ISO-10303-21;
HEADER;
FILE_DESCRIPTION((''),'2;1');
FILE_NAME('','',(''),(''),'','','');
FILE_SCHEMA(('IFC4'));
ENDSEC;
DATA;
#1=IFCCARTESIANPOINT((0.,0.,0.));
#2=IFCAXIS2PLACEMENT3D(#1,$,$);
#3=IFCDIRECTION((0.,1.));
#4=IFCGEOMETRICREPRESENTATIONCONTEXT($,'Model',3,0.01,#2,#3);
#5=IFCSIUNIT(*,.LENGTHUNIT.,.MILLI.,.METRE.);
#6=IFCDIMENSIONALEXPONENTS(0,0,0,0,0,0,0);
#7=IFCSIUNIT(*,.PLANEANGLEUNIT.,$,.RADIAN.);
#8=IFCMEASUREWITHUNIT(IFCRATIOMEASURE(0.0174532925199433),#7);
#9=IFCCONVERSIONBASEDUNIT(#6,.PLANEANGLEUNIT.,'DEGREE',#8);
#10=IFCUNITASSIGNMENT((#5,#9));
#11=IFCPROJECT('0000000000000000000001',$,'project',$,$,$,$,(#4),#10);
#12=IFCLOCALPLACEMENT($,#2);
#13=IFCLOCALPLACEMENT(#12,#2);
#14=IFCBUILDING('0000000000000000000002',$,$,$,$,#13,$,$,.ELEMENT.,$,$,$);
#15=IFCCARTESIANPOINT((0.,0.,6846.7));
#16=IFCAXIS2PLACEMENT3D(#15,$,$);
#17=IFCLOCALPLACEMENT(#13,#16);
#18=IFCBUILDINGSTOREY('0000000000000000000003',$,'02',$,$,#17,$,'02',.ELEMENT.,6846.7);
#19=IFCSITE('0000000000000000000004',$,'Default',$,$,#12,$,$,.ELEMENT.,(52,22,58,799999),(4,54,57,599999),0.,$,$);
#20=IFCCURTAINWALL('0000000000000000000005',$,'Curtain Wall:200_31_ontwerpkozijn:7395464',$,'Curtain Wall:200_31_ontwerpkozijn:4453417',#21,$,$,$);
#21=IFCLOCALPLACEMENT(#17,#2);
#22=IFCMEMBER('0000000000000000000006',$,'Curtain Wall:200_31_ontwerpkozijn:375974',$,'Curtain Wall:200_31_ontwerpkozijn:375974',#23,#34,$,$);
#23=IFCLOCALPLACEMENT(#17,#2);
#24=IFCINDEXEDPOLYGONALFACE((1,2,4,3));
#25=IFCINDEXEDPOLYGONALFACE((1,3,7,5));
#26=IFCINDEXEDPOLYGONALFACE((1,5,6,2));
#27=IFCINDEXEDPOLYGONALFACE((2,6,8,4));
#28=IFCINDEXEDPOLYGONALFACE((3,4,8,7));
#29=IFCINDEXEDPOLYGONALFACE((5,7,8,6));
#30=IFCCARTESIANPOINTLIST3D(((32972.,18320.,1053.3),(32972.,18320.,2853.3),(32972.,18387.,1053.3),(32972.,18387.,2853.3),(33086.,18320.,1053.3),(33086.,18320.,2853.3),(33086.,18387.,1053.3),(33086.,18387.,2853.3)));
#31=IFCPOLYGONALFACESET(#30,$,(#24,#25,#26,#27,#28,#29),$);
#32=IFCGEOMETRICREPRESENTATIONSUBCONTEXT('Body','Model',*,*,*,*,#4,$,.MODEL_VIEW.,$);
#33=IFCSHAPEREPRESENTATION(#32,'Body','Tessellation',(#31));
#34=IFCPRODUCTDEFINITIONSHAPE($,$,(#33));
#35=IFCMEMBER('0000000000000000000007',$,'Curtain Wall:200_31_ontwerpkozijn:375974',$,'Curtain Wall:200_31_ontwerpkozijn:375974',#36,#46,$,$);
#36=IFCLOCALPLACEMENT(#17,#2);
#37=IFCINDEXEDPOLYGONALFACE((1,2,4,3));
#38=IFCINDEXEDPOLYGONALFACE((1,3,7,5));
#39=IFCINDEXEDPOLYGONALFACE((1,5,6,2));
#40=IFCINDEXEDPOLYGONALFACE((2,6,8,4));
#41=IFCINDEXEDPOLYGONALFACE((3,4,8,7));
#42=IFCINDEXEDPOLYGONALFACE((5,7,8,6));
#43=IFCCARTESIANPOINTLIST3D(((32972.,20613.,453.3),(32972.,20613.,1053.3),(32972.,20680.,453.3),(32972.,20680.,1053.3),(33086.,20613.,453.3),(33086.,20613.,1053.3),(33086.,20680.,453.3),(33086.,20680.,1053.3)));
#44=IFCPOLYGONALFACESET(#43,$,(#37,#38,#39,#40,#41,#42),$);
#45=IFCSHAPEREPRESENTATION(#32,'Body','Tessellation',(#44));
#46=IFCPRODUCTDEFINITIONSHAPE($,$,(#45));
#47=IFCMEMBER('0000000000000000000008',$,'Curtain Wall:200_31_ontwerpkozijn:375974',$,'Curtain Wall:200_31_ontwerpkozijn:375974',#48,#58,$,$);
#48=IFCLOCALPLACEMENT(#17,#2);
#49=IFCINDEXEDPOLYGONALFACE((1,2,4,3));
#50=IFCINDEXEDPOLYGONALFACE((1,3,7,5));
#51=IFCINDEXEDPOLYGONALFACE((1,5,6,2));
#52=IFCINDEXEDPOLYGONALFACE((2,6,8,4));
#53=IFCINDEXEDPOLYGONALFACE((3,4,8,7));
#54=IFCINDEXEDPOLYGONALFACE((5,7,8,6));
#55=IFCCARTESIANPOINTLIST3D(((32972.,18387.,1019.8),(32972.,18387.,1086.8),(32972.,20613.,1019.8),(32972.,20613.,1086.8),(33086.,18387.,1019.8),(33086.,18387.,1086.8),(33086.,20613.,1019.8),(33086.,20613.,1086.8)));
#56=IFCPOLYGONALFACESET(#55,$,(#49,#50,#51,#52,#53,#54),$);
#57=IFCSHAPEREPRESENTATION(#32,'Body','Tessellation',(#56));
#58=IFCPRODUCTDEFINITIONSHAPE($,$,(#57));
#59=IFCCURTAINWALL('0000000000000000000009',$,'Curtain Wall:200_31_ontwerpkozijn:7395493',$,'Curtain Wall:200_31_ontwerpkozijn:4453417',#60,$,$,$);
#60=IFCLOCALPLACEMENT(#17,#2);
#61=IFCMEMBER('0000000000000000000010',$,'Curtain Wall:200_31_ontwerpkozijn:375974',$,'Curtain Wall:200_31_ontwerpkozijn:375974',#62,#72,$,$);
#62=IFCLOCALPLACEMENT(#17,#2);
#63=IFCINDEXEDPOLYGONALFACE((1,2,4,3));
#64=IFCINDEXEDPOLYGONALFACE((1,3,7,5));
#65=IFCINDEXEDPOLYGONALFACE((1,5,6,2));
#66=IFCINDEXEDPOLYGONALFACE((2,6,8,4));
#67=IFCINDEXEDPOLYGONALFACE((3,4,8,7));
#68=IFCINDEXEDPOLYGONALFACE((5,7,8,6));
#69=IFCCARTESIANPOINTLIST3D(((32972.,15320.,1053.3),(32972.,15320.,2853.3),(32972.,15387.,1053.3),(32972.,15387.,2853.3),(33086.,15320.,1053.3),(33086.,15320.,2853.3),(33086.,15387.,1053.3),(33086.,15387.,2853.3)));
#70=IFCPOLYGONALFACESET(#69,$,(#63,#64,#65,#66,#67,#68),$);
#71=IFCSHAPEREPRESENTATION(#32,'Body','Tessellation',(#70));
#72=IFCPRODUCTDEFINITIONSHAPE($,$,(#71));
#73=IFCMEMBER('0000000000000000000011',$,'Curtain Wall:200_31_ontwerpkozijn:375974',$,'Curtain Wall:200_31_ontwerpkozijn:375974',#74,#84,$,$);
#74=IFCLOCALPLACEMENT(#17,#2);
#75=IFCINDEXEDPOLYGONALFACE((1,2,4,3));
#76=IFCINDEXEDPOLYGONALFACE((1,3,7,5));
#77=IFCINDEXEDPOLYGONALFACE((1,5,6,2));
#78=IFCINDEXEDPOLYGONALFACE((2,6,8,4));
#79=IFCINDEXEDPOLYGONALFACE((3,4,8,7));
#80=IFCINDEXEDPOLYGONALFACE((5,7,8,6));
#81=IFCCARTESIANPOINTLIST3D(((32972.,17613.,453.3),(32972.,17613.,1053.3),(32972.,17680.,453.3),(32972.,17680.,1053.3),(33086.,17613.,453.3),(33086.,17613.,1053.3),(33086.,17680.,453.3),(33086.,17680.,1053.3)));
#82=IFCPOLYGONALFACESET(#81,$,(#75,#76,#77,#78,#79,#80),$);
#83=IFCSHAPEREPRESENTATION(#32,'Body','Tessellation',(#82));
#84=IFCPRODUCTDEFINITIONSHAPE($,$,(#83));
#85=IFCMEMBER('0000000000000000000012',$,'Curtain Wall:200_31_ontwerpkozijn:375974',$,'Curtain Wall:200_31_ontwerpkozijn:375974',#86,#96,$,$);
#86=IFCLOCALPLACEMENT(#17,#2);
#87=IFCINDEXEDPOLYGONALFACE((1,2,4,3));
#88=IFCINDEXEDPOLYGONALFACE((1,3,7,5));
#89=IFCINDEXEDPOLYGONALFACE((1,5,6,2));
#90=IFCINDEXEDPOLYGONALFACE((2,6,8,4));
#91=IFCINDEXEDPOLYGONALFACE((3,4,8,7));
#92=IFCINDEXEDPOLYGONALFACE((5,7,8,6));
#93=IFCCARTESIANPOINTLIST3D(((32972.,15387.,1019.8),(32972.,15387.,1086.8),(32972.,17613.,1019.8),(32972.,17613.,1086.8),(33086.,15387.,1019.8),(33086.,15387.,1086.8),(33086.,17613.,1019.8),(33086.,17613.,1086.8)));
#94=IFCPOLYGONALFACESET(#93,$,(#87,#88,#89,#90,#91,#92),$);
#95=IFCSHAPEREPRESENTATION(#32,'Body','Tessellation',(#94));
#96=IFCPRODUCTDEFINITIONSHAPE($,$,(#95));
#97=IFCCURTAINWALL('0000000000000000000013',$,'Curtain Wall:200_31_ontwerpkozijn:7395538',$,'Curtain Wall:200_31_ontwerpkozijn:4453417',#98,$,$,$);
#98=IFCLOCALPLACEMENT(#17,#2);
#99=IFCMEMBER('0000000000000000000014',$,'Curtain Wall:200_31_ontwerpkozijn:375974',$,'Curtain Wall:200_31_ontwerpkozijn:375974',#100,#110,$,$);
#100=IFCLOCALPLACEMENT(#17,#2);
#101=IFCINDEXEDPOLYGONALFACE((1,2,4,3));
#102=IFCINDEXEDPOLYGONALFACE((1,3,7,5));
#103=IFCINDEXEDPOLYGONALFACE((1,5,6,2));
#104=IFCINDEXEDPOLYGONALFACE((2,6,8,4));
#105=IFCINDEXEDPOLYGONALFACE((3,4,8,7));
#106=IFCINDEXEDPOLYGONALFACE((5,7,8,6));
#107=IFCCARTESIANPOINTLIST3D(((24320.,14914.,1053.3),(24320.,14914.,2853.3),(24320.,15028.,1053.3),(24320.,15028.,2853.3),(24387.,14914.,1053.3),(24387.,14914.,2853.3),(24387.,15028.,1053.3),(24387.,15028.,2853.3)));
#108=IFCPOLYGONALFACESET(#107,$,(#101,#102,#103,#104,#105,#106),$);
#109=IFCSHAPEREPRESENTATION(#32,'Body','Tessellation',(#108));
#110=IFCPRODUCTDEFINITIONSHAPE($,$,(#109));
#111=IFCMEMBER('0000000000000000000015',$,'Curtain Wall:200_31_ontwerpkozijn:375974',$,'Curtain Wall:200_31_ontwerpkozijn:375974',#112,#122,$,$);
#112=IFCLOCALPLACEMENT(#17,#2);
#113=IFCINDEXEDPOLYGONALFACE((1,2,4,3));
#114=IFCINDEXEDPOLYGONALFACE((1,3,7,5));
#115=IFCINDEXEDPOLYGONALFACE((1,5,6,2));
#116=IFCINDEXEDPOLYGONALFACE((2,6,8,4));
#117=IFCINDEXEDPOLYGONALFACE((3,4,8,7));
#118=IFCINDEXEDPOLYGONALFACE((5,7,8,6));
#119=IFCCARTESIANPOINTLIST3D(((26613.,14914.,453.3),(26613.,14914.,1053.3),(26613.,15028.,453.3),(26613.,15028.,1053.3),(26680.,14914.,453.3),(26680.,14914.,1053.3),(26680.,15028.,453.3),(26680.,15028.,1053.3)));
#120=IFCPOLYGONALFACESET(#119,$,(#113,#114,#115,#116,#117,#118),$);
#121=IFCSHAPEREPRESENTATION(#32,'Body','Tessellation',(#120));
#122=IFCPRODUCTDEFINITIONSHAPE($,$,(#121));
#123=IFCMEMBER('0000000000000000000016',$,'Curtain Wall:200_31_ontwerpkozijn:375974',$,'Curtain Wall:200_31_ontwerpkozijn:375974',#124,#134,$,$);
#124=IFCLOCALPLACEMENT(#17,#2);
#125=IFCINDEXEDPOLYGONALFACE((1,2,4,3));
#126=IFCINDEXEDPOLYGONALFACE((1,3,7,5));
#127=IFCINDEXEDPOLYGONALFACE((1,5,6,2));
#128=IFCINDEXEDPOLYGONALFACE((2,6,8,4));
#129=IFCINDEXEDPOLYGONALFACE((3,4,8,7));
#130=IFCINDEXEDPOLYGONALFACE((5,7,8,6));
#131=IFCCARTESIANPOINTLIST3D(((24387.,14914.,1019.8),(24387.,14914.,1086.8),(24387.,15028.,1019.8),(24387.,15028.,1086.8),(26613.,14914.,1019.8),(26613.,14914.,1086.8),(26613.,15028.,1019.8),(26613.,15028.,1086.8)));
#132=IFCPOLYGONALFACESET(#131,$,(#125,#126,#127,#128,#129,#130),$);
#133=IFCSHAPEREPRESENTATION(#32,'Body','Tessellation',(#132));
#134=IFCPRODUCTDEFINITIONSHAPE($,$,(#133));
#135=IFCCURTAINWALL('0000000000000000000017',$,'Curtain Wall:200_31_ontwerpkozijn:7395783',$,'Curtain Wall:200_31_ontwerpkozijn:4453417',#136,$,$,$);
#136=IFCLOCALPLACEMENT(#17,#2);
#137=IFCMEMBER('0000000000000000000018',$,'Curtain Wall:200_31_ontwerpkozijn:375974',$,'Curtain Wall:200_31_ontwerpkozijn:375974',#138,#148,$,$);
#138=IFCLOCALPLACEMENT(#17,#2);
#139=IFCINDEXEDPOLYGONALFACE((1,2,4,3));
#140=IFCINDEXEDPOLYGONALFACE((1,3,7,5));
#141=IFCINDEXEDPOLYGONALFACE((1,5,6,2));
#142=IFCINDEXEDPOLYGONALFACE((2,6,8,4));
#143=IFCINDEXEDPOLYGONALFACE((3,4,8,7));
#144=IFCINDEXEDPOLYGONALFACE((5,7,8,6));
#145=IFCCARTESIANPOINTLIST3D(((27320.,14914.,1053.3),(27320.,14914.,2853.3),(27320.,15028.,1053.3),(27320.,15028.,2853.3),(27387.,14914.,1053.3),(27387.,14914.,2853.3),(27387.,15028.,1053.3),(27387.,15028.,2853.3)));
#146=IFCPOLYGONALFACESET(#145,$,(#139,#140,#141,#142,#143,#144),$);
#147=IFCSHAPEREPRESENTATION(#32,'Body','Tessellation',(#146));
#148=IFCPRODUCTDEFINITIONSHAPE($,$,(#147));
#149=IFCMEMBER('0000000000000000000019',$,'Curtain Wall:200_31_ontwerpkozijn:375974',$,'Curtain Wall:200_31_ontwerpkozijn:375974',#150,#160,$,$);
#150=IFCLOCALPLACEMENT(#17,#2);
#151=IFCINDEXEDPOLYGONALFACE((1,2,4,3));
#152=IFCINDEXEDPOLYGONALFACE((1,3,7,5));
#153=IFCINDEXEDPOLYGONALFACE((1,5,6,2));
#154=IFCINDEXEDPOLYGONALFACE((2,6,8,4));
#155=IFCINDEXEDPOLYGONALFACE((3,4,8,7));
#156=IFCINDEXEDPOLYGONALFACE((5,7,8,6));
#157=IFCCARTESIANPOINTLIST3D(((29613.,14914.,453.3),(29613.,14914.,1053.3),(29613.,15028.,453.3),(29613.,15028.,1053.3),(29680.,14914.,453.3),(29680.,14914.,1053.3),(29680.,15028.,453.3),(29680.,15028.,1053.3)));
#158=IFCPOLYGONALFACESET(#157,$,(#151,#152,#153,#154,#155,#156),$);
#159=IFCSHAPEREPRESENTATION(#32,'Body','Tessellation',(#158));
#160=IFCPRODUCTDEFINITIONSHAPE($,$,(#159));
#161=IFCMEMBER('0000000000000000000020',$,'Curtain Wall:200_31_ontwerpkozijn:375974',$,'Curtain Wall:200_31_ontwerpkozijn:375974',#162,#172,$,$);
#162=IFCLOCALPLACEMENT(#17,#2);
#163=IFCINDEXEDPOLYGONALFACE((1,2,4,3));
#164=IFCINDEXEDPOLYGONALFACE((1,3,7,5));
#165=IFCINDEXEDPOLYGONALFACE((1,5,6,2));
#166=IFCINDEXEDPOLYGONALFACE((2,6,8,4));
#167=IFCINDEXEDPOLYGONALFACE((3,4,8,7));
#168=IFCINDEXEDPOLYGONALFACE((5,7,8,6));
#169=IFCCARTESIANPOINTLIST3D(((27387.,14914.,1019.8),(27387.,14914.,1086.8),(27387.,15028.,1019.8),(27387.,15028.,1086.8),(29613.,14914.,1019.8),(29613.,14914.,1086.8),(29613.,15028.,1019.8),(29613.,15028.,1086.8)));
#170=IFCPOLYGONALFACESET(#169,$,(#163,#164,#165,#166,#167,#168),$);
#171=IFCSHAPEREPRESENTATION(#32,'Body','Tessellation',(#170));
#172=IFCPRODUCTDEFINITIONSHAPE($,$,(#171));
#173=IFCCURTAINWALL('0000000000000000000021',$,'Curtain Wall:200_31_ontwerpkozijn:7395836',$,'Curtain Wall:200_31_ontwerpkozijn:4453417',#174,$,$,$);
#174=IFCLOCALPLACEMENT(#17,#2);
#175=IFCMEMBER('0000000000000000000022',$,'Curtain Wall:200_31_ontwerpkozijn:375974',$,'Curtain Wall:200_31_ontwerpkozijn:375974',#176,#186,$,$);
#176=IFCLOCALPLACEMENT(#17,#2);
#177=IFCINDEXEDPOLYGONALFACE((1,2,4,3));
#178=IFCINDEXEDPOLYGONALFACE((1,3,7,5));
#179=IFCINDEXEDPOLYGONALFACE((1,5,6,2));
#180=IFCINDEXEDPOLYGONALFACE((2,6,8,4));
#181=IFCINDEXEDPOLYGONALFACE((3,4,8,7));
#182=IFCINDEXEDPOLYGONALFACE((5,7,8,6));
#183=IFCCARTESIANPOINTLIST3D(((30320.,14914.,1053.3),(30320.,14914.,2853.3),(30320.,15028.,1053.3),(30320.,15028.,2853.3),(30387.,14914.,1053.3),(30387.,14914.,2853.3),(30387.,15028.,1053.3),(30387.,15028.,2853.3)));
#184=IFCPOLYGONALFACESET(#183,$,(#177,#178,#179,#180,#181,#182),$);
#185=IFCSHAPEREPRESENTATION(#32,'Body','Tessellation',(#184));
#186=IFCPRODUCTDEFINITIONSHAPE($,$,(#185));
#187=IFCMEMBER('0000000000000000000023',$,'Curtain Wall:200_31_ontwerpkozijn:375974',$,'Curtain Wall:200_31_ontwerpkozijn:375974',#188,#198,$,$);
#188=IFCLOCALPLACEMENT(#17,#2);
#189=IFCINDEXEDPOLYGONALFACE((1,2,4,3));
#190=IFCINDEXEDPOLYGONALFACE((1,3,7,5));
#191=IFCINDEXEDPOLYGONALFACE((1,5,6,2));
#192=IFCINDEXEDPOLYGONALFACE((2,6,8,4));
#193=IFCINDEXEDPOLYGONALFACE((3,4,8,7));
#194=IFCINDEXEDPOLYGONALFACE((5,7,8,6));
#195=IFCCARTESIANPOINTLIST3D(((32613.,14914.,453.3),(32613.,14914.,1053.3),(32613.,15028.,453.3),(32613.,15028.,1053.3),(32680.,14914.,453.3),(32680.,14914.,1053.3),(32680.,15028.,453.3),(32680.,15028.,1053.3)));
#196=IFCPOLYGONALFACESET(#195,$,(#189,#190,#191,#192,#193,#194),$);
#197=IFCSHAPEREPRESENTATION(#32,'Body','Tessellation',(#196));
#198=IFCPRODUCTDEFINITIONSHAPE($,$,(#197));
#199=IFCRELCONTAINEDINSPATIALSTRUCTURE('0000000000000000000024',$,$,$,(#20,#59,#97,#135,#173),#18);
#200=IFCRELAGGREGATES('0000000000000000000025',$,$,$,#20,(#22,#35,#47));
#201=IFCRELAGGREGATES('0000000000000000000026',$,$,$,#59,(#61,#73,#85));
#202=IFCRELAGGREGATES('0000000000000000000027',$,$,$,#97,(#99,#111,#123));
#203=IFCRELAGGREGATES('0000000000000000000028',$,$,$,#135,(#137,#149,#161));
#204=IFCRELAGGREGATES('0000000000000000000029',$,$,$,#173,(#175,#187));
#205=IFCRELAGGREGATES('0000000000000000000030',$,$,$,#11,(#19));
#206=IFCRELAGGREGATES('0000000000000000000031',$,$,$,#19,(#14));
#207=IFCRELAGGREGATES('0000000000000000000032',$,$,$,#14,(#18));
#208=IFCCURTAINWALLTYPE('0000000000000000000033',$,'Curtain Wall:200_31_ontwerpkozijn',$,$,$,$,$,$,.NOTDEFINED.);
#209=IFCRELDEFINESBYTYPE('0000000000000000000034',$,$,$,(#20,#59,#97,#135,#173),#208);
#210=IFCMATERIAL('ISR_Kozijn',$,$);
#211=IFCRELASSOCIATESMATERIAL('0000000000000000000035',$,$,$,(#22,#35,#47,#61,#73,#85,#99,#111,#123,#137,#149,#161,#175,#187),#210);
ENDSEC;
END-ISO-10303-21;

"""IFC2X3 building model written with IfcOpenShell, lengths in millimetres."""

from ifc_helpers import new_model, entity, si_unit, converted_unit, direction, frame, frame_2d, origin, origin_2d_with_axis, place, context, subcontext, project, spatial, rectangle, extrude, material, type_object, element, aggregate, save


model = new_model("IFC2X3")

# Units and contexts
model_context = context("Model", 3, precision=0.01, world=origin(), true_north=direction((0.0, 1.0)))
body_context = subcontext(model_context, "Body", "Model", "MODEL_VIEW")
ifc_project = project(units=[si_unit("LENGTHUNIT", "METRE", prefix="MILLI"), converted_unit("PLANEANGLEUNIT", "DEGREE", entity("IfcRatioMeasure", 0.0174532925199433), si_unit("PLANEANGLEUNIT", "RADIAN"), dimensions=[0, 0, 0, 0, 0, 0, 0])], contexts=[model_context])

# Site, building, storey
site_placement = place(None, origin())
site = spatial("IfcSite", under=ifc_project, at=site_placement, Name="Default", CompositionType="ELEMENT", RefLatitude=(52, 22, 58, 799999), RefLongitude=(4, 54, 57, 599999), RefElevation=0.0)
building_placement = place(site_placement, origin())
building = spatial("IfcBuilding", under=site, at=building_placement, CompositionType="ELEMENT")
storey_placement = place(building_placement, frame((0.0, 0.0, 6846.7)))
storey = spatial("IfcBuildingStorey", under=building, at=storey_placement, Name="02", LongName="02", CompositionType="ELEMENT", Elevation=6846.7)

# Curtain walls, members
curtain_wall_type = type_object("IfcCurtainWallType", Name="Curtain Wall:200_31_ontwerpkozijn", PredefinedType="NOTDEFINED")
curtain_wall_1_placement = place(storey_placement, frame((0.0, 0.0, -6846.7)))
curtain_wall_1 = element("IfcCurtainWall", 1, at=curtain_wall_1_placement, inside=storey, type_object=curtain_wall_type, Name="Curtain Wall:200_31_ontwerpkozijn:7395464", ObjectType="Curtain Wall:200_31_ontwerpkozijn:4453417")
ifc_material = material(Name="ISR_Kozijn")
member_1_placement = place(curtain_wall_1_placement, frame((0.0, 0.0, 6846.7)))
member_1 = element("IfcMember", 2, at=member_1_placement, material=ifc_material, Name="Curtain Wall:200_31_ontwerpkozijn:375974", ObjectType="Curtain Wall:200_31_ontwerpkozijn:375974", context=body_context, shape_type="SweptSolid", body=[
    extrude(rectangle(XDim=114.0, YDim=67.0, at=frame_2d((0.0, 0.0), x_axis=(1.0, 0.0))), frame((33029.0, 18353.5, 1053.3), z_axis=(0.0, 0.0, 1.0), x_axis=(-1.0, 0.0, 0.0)), (0.0, 0.0, 1.0), 1800.0),
])
member_2_placement = place(curtain_wall_1_placement, frame((0.0, 0.0, 6846.7)))
member_2 = element("IfcMember", 3, at=member_2_placement, material=ifc_material, Name="Curtain Wall:200_31_ontwerpkozijn:375974", ObjectType="Curtain Wall:200_31_ontwerpkozijn:375974", context=body_context, shape_type="SweptSolid", body=[
    extrude(rectangle(XDim=114.0, YDim=67.0, at=origin_2d_with_axis()), frame((33029.0, 20646.5, 1053.3), z_axis=(0.0, 0.0, -1.0), x_axis=(-1.0, 0.0, 0.0)), (0.0, 0.0, 1.0), 600.0),
])
member_3_placement = place(curtain_wall_1_placement, frame((0.0, 0.0, 6846.7)))
member_3 = element("IfcMember", 4, at=member_3_placement, material=ifc_material, Name="Curtain Wall:200_31_ontwerpkozijn:375974", ObjectType="Curtain Wall:200_31_ontwerpkozijn:375974", context=body_context, shape_type="SweptSolid", body=[
    extrude(rectangle(XDim=67.0, YDim=114.0, at=frame_2d((0.0, 0.0), x_axis=(1.0, 0.0))), frame((33029.0, 18387.0, 1053.3), z_axis=(0.0, 1.0, 0.0), x_axis=(0.0, 0.0, -1.0)), (0.0, 0.0, 1.0), 2226.0),
])
aggregate(curtain_wall_1, [member_1, member_2, member_3])
curtain_wall_2_placement = place(storey_placement, frame((0.0, 0.0, -6846.7)))
curtain_wall_2 = element("IfcCurtainWall", 5, at=curtain_wall_2_placement, inside=storey, type_object=curtain_wall_type, Name="Curtain Wall:200_31_ontwerpkozijn:7395493", ObjectType="Curtain Wall:200_31_ontwerpkozijn:4453417")
member_4_placement = place(curtain_wall_2_placement, frame((0.0, 0.0, 6846.7)))
member_4 = element("IfcMember", 6, at=member_4_placement, material=ifc_material, Name="Curtain Wall:200_31_ontwerpkozijn:375974", ObjectType="Curtain Wall:200_31_ontwerpkozijn:375974", context=body_context, shape_type="SweptSolid", body=[
    extrude(rectangle(XDim=114.0, YDim=67.0, at=frame_2d((0.0, 0.0), x_axis=(1.0, 0.0))), frame((33029.0, 15353.5, 1053.3), z_axis=(0.0, 0.0, 1.0), x_axis=(-1.0, 0.0, 0.0)), (0.0, 0.0, 1.0), 1800.0),
])
member_5_placement = place(curtain_wall_2_placement, frame((0.0, 0.0, 6846.7)))
member_5 = element("IfcMember", 7, at=member_5_placement, material=ifc_material, Name="Curtain Wall:200_31_ontwerpkozijn:375974", ObjectType="Curtain Wall:200_31_ontwerpkozijn:375974", context=body_context, shape_type="SweptSolid", body=[
    extrude(rectangle(XDim=114.0, YDim=67.0, at=frame_2d((0.0, 0.0), x_axis=(1.0, 0.0))), frame((33029.0, 17646.5, 1053.3), z_axis=(0.0, 0.0, -1.0), x_axis=(-1.0, 0.0, 0.0)), (0.0, 0.0, 1.0), 600.0),
])
member_6_placement = place(curtain_wall_2_placement, frame((0.0, 0.0, 6846.7)))
member_6 = element("IfcMember", 8, at=member_6_placement, material=ifc_material, Name="Curtain Wall:200_31_ontwerpkozijn:375974", ObjectType="Curtain Wall:200_31_ontwerpkozijn:375974", context=body_context, shape_type="SweptSolid", body=[
    extrude(rectangle(XDim=67.0, YDim=114.0, at=frame_2d((0.0, 0.0), x_axis=(1.0, 0.0))), frame((33029.0, 15387.0, 1053.3), z_axis=(0.0, 1.0, 0.0), x_axis=(0.0, 0.0, -1.0)), (0.0, 0.0, 1.0), 2226.0),
])
aggregate(curtain_wall_2, [member_4, member_5, member_6])
curtain_wall_3_placement = place(storey_placement, frame((0.0, 0.0, -6846.7)))
curtain_wall_3 = element("IfcCurtainWall", 9, at=curtain_wall_3_placement, inside=storey, type_object=curtain_wall_type, Name="Curtain Wall:200_31_ontwerpkozijn:7395538", ObjectType="Curtain Wall:200_31_ontwerpkozijn:4453417")
member_7_placement = place(curtain_wall_3_placement, frame((0.0, 0.0, 6846.7)))
member_7 = element("IfcMember", 10, at=member_7_placement, material=ifc_material, Name="Curtain Wall:200_31_ontwerpkozijn:375974", ObjectType="Curtain Wall:200_31_ontwerpkozijn:375974", context=body_context, shape_type="SweptSolid", body=[
    extrude(rectangle(XDim=67.0, YDim=114.0, at=origin_2d_with_axis()), frame((24353.5, 14971.0, 1053.3), z_axis=(0.0, 0.0, 1.0), x_axis=(-1.0, 0.0, 0.0)), (0.0, 0.0, 1.0), 1800.0),
])
member_8_placement = place(curtain_wall_3_placement, frame((0.0, 0.0, 6846.7)))
member_8 = element("IfcMember", 11, at=member_8_placement, material=ifc_material, Name="Curtain Wall:200_31_ontwerpkozijn:375974", ObjectType="Curtain Wall:200_31_ontwerpkozijn:375974", context=body_context, shape_type="SweptSolid", body=[
    extrude(rectangle(XDim=67.0, YDim=114.0, at=origin_2d_with_axis()), frame((26646.5, 14971.0, 1053.3), z_axis=(0.0, 0.0, -1.0), x_axis=(-1.0, 0.0, 0.0)), (0.0, 0.0, 1.0), 600.0),
])
member_9_placement = place(curtain_wall_3_placement, frame((0.0, 0.0, 6846.7)))
member_9 = element("IfcMember", 12, at=member_9_placement, material=ifc_material, Name="Curtain Wall:200_31_ontwerpkozijn:375974", ObjectType="Curtain Wall:200_31_ontwerpkozijn:375974", context=body_context, shape_type="SweptSolid", body=[
    extrude(rectangle(XDim=67.0, YDim=114.0, at=frame_2d((0.0, 0.0), x_axis=(1.0, 0.0))), frame((24387.0, 14971.0, 1053.3), z_axis=(1.0, 0.0, 0.0), x_axis=(0.0, 0.0, -1.0)), (0.0, 0.0, 1.0), 2226.0),
])
aggregate(curtain_wall_3, [member_7, member_8, member_9])
curtain_wall_4_placement = place(storey_placement, frame((0.0, 0.0, -6846.7)))
curtain_wall_4 = element("IfcCurtainWall", 13, at=curtain_wall_4_placement, inside=storey, type_object=curtain_wall_type, Name="Curtain Wall:200_31_ontwerpkozijn:7395783", ObjectType="Curtain Wall:200_31_ontwerpkozijn:4453417")
member_10_placement = place(curtain_wall_4_placement, frame((0.0, 0.0, 6846.7)))
member_10 = element("IfcMember", 14, at=member_10_placement, material=ifc_material, Name="Curtain Wall:200_31_ontwerpkozijn:375974", ObjectType="Curtain Wall:200_31_ontwerpkozijn:375974", context=body_context, shape_type="SweptSolid", body=[
    extrude(rectangle(XDim=67.0, YDim=114.0, at=origin_2d_with_axis()), frame((27353.5, 14971.0, 1053.3), z_axis=(0.0, 0.0, 1.0), x_axis=(-1.0, 0.0, 0.0)), (0.0, 0.0, 1.0), 1800.0),
])
member_11_placement = place(curtain_wall_4_placement, frame((0.0, 0.0, 6846.7)))
member_11 = element("IfcMember", 15, at=member_11_placement, material=ifc_material, Name="Curtain Wall:200_31_ontwerpkozijn:375974", ObjectType="Curtain Wall:200_31_ontwerpkozijn:375974", context=body_context, shape_type="SweptSolid", body=[
    extrude(rectangle(XDim=67.0, YDim=114.0, at=origin_2d_with_axis()), frame((29646.5, 14971.0, 1053.3), z_axis=(0.0, 0.0, -1.0), x_axis=(-1.0, 0.0, 0.0)), (0.0, 0.0, 1.0), 600.0),
])
member_12_placement = place(curtain_wall_4_placement, frame((0.0, 0.0, 6846.7)))
member_12 = element("IfcMember", 16, at=member_12_placement, material=ifc_material, Name="Curtain Wall:200_31_ontwerpkozijn:375974", ObjectType="Curtain Wall:200_31_ontwerpkozijn:375974", context=body_context, shape_type="SweptSolid", body=[
    extrude(rectangle(XDim=67.0, YDim=114.0, at=frame_2d((0.0, 0.0), x_axis=(1.0, 0.0))), frame((27387.0, 14971.0, 1053.3), z_axis=(1.0, 0.0, 0.0), x_axis=(0.0, 0.0, -1.0)), (0.0, 0.0, 1.0), 2226.0),
])
aggregate(curtain_wall_4, [member_10, member_11, member_12])
curtain_wall_5_placement = place(storey_placement, frame((0.0, 0.0, -6846.7)))
curtain_wall_5 = element("IfcCurtainWall", 17, at=curtain_wall_5_placement, inside=storey, type_object=curtain_wall_type, Name="Curtain Wall:200_31_ontwerpkozijn:7395836", ObjectType="Curtain Wall:200_31_ontwerpkozijn:4453417")
member_13_placement = place(curtain_wall_5_placement, frame((0.0, 0.0, 6846.7)))
member_13 = element("IfcMember", 18, at=member_13_placement, material=ifc_material, Name="Curtain Wall:200_31_ontwerpkozijn:375974", ObjectType="Curtain Wall:200_31_ontwerpkozijn:375974", context=body_context, shape_type="SweptSolid", body=[
    extrude(rectangle(XDim=67.0, YDim=114.0, at=origin_2d_with_axis()), frame((30353.5, 14971.0, 1053.3), z_axis=(0.0, 0.0, 1.0), x_axis=(-1.0, 0.0, 0.0)), (0.0, 0.0, 1.0), 1800.0),
])
member_14_placement = place(curtain_wall_5_placement, frame((0.0, 0.0, 6846.7)))
member_14 = element("IfcMember", 19, at=member_14_placement, material=ifc_material, Name="Curtain Wall:200_31_ontwerpkozijn:375974", ObjectType="Curtain Wall:200_31_ontwerpkozijn:375974", context=body_context, shape_type="SweptSolid", body=[
    extrude(rectangle(XDim=67.0, YDim=114.0, at=origin_2d_with_axis()), frame((32646.5, 14971.0, 1053.3), z_axis=(0.0, 0.0, -1.0), x_axis=(-1.0, 0.0, 0.0)), (0.0, 0.0, 1.0), 600.0),
])
aggregate(curtain_wall_5, [member_13, member_14])

save(model, "model.ifc")
